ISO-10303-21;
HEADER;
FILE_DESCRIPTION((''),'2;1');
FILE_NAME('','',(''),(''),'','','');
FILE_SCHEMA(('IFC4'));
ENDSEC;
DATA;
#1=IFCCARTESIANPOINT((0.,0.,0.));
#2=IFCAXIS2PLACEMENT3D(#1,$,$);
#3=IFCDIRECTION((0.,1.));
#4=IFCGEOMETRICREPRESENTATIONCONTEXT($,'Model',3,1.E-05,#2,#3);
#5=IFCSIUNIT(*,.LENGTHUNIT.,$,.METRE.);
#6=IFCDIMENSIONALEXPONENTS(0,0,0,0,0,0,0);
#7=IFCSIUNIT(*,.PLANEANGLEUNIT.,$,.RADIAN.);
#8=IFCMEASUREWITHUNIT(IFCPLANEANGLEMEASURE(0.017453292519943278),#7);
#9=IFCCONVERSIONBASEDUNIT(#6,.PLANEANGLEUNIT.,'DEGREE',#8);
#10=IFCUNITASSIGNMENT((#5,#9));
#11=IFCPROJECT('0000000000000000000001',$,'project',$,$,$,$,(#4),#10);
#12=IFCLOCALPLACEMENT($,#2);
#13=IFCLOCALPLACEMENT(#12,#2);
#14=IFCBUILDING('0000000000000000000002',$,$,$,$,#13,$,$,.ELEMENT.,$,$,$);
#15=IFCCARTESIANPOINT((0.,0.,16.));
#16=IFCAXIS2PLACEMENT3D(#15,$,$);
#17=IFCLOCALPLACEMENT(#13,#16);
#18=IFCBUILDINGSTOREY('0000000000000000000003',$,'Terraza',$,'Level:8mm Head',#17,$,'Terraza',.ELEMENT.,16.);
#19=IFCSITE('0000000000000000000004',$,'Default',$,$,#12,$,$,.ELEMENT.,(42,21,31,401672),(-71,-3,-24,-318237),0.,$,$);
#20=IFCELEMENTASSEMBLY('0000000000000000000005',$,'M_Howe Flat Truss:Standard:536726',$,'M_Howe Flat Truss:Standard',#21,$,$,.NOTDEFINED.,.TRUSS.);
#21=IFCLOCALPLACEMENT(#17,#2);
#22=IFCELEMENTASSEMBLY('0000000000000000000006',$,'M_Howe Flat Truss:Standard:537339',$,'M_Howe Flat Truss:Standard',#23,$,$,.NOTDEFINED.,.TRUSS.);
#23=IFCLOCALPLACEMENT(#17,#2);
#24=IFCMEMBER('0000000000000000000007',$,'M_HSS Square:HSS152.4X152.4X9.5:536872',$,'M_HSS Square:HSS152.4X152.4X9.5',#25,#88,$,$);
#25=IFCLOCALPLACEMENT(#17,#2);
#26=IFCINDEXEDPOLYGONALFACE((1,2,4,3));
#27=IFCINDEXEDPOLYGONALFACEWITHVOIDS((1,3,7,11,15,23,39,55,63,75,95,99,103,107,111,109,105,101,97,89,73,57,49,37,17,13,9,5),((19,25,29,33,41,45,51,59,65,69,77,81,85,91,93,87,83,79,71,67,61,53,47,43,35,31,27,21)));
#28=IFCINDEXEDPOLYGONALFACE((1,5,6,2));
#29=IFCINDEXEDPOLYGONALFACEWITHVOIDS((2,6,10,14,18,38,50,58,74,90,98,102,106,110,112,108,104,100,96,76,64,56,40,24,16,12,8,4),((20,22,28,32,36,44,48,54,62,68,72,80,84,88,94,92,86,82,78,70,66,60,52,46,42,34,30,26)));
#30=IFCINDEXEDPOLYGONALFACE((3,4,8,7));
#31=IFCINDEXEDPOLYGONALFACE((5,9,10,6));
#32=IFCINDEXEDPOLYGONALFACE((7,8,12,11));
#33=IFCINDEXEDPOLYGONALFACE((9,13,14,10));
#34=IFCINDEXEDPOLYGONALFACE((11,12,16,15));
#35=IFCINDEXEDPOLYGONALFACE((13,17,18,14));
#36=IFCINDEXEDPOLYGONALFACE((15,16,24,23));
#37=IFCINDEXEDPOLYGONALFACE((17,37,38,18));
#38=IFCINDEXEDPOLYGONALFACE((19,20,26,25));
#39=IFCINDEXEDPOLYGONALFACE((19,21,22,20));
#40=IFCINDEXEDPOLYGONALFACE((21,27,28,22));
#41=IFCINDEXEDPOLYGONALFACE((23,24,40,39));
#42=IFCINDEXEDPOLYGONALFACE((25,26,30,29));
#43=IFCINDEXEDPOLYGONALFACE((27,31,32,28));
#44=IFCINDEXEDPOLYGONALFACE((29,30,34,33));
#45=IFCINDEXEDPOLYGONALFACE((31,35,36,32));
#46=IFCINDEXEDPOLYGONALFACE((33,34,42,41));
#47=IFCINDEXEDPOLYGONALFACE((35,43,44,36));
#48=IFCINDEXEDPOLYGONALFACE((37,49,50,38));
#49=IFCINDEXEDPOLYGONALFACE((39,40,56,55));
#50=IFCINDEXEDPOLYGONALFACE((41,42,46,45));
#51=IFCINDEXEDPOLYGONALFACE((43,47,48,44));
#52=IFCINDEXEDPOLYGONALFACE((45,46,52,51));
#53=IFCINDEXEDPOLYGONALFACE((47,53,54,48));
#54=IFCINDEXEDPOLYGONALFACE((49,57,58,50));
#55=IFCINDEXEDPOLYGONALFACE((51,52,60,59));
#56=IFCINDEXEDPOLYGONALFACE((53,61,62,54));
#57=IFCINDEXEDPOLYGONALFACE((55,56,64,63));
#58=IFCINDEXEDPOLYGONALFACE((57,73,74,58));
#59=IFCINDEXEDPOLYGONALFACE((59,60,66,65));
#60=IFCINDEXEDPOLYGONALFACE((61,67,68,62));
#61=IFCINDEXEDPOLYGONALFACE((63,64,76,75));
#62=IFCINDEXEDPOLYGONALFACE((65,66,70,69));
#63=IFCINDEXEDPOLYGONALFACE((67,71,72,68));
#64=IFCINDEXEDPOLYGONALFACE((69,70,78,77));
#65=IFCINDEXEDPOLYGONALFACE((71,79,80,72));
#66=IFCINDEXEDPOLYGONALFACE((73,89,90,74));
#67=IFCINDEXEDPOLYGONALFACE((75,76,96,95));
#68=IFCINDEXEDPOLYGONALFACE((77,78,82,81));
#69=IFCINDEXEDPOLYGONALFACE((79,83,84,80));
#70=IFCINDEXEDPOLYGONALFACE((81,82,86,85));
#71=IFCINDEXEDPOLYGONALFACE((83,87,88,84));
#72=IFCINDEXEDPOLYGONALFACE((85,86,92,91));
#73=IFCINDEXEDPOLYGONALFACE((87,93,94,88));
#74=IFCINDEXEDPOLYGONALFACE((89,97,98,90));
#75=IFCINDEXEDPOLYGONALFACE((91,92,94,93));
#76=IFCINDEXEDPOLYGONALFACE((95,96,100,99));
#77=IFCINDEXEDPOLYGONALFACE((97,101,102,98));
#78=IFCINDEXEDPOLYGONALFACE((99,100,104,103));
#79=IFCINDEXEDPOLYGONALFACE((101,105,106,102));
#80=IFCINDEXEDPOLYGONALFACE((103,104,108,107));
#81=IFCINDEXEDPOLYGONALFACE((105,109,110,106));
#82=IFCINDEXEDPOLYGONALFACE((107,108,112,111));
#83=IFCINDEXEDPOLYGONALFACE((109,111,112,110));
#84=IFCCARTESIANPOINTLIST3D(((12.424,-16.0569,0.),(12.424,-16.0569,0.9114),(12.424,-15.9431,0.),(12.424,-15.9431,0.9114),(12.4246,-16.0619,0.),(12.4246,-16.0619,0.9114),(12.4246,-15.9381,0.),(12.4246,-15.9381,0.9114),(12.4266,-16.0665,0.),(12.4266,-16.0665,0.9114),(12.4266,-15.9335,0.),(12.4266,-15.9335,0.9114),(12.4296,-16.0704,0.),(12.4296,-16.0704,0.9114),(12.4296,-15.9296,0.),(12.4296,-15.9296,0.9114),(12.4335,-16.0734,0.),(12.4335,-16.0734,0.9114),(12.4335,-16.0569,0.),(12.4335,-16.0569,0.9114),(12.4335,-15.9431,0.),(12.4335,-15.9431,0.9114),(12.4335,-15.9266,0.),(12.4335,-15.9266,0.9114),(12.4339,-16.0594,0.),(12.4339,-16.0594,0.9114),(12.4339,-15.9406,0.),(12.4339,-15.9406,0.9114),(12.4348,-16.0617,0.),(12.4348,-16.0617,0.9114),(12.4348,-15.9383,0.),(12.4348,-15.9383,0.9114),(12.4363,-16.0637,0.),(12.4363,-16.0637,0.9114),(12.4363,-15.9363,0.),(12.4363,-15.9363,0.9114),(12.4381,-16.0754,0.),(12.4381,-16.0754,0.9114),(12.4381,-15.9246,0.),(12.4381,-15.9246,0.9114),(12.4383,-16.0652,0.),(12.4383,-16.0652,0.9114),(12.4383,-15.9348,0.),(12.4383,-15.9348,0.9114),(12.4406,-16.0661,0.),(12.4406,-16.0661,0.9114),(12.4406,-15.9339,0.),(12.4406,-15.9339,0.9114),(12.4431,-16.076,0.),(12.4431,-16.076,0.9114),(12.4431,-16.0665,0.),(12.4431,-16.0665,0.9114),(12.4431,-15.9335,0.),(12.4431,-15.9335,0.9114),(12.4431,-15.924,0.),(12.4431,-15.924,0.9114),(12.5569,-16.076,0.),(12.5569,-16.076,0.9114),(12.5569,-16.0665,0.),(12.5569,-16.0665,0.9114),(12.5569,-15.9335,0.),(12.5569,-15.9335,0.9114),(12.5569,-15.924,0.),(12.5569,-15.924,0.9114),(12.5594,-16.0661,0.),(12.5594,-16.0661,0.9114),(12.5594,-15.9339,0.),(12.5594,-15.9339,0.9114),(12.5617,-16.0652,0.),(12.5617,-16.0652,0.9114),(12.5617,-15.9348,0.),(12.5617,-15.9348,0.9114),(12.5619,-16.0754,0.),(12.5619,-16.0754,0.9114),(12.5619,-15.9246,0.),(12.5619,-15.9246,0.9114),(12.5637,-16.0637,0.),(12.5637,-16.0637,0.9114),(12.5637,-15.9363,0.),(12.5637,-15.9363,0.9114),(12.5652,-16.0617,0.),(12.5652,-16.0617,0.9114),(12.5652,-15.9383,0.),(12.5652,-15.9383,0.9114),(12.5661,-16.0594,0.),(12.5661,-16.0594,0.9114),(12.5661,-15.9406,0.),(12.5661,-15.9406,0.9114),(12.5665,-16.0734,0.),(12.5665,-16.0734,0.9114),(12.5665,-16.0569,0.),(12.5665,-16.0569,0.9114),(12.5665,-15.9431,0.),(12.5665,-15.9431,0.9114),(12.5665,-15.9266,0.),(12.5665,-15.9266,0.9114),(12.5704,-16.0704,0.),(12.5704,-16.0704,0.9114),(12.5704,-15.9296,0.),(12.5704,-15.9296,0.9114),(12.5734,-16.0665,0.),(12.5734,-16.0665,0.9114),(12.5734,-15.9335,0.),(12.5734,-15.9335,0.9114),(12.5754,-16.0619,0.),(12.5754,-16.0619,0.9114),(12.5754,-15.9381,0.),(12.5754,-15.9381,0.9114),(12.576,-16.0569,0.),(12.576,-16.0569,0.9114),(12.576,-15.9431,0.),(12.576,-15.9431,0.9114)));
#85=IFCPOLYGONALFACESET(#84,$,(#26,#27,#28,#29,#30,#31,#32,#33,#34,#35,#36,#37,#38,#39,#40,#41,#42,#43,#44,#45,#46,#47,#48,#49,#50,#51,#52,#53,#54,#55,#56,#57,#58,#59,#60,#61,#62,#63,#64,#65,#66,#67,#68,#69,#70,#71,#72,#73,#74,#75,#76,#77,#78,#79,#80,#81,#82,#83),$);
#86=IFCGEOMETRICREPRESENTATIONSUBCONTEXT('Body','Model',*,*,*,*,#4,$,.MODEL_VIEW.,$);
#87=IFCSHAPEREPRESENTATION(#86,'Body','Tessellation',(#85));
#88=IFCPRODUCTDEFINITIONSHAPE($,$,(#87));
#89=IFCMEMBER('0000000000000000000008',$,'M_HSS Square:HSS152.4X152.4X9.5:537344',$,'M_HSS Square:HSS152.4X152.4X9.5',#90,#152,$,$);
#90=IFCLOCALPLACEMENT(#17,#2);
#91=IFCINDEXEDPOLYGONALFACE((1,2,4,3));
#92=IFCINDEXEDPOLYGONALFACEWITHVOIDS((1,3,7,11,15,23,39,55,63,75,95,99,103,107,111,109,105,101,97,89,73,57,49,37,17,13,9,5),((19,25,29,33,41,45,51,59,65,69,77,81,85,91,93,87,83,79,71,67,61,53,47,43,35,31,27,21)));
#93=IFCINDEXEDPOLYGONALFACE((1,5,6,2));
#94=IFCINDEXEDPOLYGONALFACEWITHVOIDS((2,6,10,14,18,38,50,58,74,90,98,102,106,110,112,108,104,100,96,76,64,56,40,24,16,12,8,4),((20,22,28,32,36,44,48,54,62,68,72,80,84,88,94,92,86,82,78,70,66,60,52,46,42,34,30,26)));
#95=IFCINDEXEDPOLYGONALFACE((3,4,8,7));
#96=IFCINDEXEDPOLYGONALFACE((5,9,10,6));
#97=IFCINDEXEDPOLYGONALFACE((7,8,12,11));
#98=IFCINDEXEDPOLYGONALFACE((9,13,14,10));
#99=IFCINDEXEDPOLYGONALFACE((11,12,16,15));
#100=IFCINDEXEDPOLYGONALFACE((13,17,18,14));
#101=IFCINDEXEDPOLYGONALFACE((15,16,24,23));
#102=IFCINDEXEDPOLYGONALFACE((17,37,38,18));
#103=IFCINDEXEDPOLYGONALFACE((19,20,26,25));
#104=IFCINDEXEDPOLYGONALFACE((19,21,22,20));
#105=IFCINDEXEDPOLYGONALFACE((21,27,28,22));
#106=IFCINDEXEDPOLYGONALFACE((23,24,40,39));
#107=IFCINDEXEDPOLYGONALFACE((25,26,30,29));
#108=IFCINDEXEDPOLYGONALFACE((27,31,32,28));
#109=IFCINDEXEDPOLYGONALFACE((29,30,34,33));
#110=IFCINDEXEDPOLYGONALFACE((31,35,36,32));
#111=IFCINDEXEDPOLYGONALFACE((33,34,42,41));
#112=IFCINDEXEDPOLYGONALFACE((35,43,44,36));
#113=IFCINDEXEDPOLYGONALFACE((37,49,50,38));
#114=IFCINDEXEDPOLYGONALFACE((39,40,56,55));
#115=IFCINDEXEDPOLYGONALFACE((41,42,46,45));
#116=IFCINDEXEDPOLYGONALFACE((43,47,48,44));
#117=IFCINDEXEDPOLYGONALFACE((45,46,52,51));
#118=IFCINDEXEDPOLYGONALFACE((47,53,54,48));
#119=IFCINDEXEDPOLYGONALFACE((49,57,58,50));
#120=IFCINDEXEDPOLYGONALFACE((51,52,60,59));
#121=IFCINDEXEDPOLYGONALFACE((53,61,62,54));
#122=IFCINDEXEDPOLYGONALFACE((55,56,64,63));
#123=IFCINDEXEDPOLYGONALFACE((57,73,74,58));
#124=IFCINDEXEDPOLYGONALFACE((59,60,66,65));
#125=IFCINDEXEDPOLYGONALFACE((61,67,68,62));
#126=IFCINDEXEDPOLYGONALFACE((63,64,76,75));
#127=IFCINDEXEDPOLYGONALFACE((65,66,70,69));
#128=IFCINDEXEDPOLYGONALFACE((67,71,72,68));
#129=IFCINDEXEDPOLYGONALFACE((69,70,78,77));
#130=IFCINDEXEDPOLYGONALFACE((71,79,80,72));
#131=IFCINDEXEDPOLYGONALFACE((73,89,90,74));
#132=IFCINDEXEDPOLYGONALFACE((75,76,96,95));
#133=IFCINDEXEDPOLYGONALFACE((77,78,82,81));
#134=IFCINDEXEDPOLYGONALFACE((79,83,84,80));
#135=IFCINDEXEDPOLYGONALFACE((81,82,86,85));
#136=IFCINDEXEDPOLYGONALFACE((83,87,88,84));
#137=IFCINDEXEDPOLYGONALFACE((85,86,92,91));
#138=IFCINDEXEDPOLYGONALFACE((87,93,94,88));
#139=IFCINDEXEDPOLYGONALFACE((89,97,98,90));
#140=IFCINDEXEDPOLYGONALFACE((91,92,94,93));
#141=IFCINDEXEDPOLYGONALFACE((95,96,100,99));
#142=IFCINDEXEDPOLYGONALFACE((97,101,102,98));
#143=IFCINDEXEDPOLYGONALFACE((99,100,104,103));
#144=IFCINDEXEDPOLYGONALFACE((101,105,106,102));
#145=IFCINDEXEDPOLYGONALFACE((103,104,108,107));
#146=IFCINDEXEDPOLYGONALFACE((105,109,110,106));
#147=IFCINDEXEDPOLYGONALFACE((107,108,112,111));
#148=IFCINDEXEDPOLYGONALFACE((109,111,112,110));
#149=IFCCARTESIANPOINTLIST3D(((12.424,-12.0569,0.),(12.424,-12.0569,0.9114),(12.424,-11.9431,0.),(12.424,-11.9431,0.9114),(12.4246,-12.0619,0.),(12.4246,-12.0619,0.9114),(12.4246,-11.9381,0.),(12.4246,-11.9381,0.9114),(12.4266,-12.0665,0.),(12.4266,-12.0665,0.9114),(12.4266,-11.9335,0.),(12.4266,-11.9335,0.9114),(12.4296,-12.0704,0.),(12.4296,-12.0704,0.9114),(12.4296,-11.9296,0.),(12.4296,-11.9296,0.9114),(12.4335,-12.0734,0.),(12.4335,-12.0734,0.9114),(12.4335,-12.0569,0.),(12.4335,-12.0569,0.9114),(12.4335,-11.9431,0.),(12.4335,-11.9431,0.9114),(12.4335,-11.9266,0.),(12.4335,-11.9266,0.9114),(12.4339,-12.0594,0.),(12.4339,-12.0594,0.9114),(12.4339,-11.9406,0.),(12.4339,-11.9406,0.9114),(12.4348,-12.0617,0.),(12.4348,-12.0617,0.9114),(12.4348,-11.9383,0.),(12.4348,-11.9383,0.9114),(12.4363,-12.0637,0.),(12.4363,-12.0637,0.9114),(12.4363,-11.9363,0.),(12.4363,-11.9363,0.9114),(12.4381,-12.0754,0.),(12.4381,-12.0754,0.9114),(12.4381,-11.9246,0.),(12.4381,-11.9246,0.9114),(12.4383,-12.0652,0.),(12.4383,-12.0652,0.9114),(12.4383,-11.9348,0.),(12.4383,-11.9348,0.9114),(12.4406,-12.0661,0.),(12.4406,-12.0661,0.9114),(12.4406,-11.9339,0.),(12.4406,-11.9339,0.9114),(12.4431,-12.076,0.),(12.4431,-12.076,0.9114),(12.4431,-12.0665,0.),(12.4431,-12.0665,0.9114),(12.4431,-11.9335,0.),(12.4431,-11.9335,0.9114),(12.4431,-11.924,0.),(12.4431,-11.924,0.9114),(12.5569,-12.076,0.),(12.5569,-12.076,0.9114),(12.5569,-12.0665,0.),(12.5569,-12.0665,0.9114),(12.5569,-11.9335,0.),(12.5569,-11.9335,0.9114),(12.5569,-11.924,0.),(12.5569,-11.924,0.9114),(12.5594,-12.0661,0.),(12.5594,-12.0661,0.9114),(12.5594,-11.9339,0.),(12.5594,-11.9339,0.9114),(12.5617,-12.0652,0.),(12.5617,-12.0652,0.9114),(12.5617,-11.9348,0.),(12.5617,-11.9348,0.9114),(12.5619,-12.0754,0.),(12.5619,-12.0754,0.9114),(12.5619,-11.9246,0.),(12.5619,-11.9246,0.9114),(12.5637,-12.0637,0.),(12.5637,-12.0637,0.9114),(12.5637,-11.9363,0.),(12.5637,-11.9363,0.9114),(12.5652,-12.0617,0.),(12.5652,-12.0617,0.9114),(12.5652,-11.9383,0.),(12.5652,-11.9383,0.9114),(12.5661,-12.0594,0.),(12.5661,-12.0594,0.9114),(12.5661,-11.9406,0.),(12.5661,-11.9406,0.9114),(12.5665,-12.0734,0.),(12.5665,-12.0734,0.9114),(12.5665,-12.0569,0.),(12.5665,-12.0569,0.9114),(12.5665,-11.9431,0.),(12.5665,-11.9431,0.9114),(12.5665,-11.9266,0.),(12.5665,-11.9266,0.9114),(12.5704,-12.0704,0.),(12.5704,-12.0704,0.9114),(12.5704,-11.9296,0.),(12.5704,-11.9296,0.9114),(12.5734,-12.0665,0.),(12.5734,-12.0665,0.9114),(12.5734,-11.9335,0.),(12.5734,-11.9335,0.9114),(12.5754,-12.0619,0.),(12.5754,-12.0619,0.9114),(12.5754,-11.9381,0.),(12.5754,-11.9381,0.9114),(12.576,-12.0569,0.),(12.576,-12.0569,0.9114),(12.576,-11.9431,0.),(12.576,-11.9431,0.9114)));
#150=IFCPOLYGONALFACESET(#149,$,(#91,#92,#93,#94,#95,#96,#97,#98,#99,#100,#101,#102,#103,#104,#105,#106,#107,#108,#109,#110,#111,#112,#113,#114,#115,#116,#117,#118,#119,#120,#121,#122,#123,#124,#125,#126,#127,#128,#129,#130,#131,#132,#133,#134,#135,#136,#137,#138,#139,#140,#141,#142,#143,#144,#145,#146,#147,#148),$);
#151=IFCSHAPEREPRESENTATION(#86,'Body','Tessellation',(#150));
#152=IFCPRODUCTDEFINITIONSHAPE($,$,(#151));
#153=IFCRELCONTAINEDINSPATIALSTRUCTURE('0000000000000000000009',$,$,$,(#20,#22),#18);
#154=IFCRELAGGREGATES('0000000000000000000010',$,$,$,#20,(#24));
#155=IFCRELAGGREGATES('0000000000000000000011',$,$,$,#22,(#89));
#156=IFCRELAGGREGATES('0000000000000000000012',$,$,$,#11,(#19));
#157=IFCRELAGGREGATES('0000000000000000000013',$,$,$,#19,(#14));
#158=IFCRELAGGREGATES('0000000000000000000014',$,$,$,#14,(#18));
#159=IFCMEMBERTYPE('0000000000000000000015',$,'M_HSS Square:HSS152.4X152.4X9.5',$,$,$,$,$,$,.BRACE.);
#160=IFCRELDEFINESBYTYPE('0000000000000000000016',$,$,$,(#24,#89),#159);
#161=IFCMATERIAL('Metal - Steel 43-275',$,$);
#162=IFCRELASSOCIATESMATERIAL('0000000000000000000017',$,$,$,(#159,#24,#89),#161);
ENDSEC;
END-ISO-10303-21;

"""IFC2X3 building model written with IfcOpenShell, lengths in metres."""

from ifc_helpers import new_model, entity, si_unit, converted_unit, direction, frame, frame_2d, origin, place, context, subcontext, project, spatial, polyline, circle_curve, parameter, trimmed, segment, composite_curve, outline, extrude, source, transform, mapped, material, type_object, type_shapes, element, aggregate, save


model = new_model("IFC2X3")

# Units and contexts
model_context = context("Model", 3, precision=1e-05, world=origin(), true_north=direction((0.0, 1.0)))
body_context = subcontext(model_context, "Body", "Model", "MODEL_VIEW")
ifc_project = project(units=[si_unit("LENGTHUNIT", "METRE"), converted_unit("PLANEANGLEUNIT", "DEGREE", entity("IfcPlaneAngleMeasure", 0.017453292519943278), si_unit("PLANEANGLEUNIT", "RADIAN"), dimensions=[0, 0, 0, 0, 0, 0, 0])], contexts=[model_context])

# Site, building, storey
site_placement = place(None, origin())
site = spatial("IfcSite", under=ifc_project, at=site_placement, Name="Default", CompositionType="ELEMENT", RefLatitude=(42, 21, 31, 401672), RefLongitude=(-71, -3, -24, -318237), RefElevation=0.0)
building_placement = place(site_placement, origin())
building = spatial("IfcBuilding", under=site, at=building_placement, CompositionType="ELEMENT")
storey_placement = place(building_placement, frame((0.0, 0.0, 16.0)))
storey = spatial("IfcBuildingStorey", under=building, at=storey_placement, Name="Terraza", ObjectType="Level:8mm Head", LongName="Terraza", CompositionType="ELEMENT", Elevation=16.0)

# Element assemblies
assembly_1_placement = place(storey_placement, origin())
assembly_1 = element("IfcElementAssembly", 1, at=assembly_1_placement, inside=storey, Name="M_Howe Flat Truss:Standard:536726", ObjectType="M_Howe Flat Truss:Standard", AssemblyPlace="NOTDEFINED", PredefinedType="TRUSS")
ifc_material = material(Name="Metal - Steel 43-275")
assembly_2_placement = place(storey_placement, origin())
assembly_2 = element("IfcElementAssembly", 2, at=assembly_2_placement, inside=storey, Name="M_Howe Flat Truss:Standard:537339", ObjectType="M_Howe Flat Truss:Standard", AssemblyPlace="NOTDEFINED", PredefinedType="TRUSS")

# Members
member_type_1 = type_object("IfcMemberType", Name="M_HSS Square:HSS152.4X152.4X9.5", PredefinedType="BRACE", material=ifc_material)
shared_shape_1 = source(origin(), body_context, "Body", "SweptSolid", [
    extrude(outline(composite_curve([segment(polyline([(-0.0569, -0.076), (0.0569, -0.076)]), True, "CONTINUOUS"), segment(trimmed(circle_curve(frame_2d((0.0569, -0.0569), x_axis=(0.0, 1.0)), 0.0191), [parameter(180.0)], [parameter(270.0)], True, "PARAMETER"), True, "CONTINUOUS"), segment(polyline([(0.076, -0.0569), (0.076, 0.0569)]), True, "CONTINUOUS"), segment(trimmed(circle_curve(frame_2d((0.0569, 0.0569), x_axis=(0.0, 1.0)), 0.0191), [parameter(270.0)], [parameter(0.0)], True, "PARAMETER"), True, "CONTINUOUS"), segment(polyline([(0.0569, 0.076), (-0.0569, 0.076)]), True, "CONTINUOUS"), segment(trimmed(circle_curve(frame_2d((-0.0569, 0.0569), x_axis=(0.0, 1.0)), 0.0191), [parameter(0.0)], [parameter(90.0)], True, "PARAMETER"), True, "CONTINUOUS"), segment(polyline([(-0.076, 0.0569), (-0.076, -0.0569)]), True, "CONTINUOUS"), segment(trimmed(circle_curve(frame_2d((-0.0569, -0.0569), x_axis=(0.0, 1.0)), 0.0191), [parameter(90.0)], [parameter(180.0)], True, "PARAMETER"), True, "CONTINUOUS")], self_intersect=False), holes=[composite_curve([segment(trimmed(circle_curve(frame_2d((-0.0569, 0.0569), x_axis=(0.0, 1.0)), 0.0095), [parameter(360.0)], [parameter(90.0)], True, "PARAMETER"), False, "CONTINUOUS"), segment(polyline([(-0.0569, 0.0665), (0.0569, 0.0665)]), True, "CONTINUOUS"), segment(trimmed(circle_curve(frame_2d((0.0569, 0.0569), x_axis=(0.0, 1.0)), 0.0095), [parameter(270.0)], [parameter(360.0)], True, "PARAMETER"), False, "CONTINUOUS"), segment(polyline([(0.0665, 0.0569), (0.0665, -0.0569)]), True, "CONTINUOUS"), segment(trimmed(circle_curve(frame_2d((0.0569, -0.0569), x_axis=(0.0, 1.0)), 0.0095), [parameter(180.0)], [parameter(270.0)], True, "PARAMETER"), False, "CONTINUOUS"), segment(polyline([(0.0569, -0.0665), (-0.0569, -0.0665)]), True, "CONTINUOUS"), segment(trimmed(circle_curve(frame_2d((-0.0569, -0.0569), x_axis=(0.0, 1.0)), 0.0095), [parameter(90.0)], [parameter(180.0)], True, "PARAMETER"), False, "CONTINUOUS"), segment(polyline([(-0.0665, -0.0569), (-0.0665, 0.0569)]), True, "CONTINUOUS")], self_intersect=False)]), frame((-0.5, 0.0, 0.0), z_axis=(1.0, 0.0, 0.0), x_axis=(0.0, 0.0, -1.0)), (0.0, 0.0, 1.0), 0.9114),
])
type_shapes(member_type_1, [shared_shape_1])
member_1_placement = place(assembly_1_placement, frame((12.5, -16.0, 0.5), z_axis=(1.0, 0.0, 0.0), x_axis=(0.0, 0.0, 1.0)))
member_1 = element("IfcMember", 3, at=member_1_placement, type_object=member_type_1, material=ifc_material, Name="M_HSS Square:HSS152.4X152.4X9.5:536872", ObjectType="M_HSS Square:HSS152.4X152.4X9.5", context=body_context, shape_type="MappedRepresentation", body=[
    mapped(shared_shape_1, transform((0.0, 0.0, 0.0), scale=1.0)),
])
member_2_placement = place(assembly_2_placement, frame((12.5, -12.0, 0.5), z_axis=(1.0, 0.0, 0.0), x_axis=(0.0, 0.0, 1.0)))
member_2 = element("IfcMember", 4, at=member_2_placement, type_object=member_type_1, material=ifc_material, Name="M_HSS Square:HSS152.4X152.4X9.5:537344", ObjectType="M_HSS Square:HSS152.4X152.4X9.5", context=body_context, shape_type="MappedRepresentation", body=[
    mapped(shared_shape_1, transform((0.0, 0.0, 0.0), scale=1.0)),
])

aggregate(assembly_1, [member_1])
aggregate(assembly_2, [member_2])

save(model, "model.ifc")
